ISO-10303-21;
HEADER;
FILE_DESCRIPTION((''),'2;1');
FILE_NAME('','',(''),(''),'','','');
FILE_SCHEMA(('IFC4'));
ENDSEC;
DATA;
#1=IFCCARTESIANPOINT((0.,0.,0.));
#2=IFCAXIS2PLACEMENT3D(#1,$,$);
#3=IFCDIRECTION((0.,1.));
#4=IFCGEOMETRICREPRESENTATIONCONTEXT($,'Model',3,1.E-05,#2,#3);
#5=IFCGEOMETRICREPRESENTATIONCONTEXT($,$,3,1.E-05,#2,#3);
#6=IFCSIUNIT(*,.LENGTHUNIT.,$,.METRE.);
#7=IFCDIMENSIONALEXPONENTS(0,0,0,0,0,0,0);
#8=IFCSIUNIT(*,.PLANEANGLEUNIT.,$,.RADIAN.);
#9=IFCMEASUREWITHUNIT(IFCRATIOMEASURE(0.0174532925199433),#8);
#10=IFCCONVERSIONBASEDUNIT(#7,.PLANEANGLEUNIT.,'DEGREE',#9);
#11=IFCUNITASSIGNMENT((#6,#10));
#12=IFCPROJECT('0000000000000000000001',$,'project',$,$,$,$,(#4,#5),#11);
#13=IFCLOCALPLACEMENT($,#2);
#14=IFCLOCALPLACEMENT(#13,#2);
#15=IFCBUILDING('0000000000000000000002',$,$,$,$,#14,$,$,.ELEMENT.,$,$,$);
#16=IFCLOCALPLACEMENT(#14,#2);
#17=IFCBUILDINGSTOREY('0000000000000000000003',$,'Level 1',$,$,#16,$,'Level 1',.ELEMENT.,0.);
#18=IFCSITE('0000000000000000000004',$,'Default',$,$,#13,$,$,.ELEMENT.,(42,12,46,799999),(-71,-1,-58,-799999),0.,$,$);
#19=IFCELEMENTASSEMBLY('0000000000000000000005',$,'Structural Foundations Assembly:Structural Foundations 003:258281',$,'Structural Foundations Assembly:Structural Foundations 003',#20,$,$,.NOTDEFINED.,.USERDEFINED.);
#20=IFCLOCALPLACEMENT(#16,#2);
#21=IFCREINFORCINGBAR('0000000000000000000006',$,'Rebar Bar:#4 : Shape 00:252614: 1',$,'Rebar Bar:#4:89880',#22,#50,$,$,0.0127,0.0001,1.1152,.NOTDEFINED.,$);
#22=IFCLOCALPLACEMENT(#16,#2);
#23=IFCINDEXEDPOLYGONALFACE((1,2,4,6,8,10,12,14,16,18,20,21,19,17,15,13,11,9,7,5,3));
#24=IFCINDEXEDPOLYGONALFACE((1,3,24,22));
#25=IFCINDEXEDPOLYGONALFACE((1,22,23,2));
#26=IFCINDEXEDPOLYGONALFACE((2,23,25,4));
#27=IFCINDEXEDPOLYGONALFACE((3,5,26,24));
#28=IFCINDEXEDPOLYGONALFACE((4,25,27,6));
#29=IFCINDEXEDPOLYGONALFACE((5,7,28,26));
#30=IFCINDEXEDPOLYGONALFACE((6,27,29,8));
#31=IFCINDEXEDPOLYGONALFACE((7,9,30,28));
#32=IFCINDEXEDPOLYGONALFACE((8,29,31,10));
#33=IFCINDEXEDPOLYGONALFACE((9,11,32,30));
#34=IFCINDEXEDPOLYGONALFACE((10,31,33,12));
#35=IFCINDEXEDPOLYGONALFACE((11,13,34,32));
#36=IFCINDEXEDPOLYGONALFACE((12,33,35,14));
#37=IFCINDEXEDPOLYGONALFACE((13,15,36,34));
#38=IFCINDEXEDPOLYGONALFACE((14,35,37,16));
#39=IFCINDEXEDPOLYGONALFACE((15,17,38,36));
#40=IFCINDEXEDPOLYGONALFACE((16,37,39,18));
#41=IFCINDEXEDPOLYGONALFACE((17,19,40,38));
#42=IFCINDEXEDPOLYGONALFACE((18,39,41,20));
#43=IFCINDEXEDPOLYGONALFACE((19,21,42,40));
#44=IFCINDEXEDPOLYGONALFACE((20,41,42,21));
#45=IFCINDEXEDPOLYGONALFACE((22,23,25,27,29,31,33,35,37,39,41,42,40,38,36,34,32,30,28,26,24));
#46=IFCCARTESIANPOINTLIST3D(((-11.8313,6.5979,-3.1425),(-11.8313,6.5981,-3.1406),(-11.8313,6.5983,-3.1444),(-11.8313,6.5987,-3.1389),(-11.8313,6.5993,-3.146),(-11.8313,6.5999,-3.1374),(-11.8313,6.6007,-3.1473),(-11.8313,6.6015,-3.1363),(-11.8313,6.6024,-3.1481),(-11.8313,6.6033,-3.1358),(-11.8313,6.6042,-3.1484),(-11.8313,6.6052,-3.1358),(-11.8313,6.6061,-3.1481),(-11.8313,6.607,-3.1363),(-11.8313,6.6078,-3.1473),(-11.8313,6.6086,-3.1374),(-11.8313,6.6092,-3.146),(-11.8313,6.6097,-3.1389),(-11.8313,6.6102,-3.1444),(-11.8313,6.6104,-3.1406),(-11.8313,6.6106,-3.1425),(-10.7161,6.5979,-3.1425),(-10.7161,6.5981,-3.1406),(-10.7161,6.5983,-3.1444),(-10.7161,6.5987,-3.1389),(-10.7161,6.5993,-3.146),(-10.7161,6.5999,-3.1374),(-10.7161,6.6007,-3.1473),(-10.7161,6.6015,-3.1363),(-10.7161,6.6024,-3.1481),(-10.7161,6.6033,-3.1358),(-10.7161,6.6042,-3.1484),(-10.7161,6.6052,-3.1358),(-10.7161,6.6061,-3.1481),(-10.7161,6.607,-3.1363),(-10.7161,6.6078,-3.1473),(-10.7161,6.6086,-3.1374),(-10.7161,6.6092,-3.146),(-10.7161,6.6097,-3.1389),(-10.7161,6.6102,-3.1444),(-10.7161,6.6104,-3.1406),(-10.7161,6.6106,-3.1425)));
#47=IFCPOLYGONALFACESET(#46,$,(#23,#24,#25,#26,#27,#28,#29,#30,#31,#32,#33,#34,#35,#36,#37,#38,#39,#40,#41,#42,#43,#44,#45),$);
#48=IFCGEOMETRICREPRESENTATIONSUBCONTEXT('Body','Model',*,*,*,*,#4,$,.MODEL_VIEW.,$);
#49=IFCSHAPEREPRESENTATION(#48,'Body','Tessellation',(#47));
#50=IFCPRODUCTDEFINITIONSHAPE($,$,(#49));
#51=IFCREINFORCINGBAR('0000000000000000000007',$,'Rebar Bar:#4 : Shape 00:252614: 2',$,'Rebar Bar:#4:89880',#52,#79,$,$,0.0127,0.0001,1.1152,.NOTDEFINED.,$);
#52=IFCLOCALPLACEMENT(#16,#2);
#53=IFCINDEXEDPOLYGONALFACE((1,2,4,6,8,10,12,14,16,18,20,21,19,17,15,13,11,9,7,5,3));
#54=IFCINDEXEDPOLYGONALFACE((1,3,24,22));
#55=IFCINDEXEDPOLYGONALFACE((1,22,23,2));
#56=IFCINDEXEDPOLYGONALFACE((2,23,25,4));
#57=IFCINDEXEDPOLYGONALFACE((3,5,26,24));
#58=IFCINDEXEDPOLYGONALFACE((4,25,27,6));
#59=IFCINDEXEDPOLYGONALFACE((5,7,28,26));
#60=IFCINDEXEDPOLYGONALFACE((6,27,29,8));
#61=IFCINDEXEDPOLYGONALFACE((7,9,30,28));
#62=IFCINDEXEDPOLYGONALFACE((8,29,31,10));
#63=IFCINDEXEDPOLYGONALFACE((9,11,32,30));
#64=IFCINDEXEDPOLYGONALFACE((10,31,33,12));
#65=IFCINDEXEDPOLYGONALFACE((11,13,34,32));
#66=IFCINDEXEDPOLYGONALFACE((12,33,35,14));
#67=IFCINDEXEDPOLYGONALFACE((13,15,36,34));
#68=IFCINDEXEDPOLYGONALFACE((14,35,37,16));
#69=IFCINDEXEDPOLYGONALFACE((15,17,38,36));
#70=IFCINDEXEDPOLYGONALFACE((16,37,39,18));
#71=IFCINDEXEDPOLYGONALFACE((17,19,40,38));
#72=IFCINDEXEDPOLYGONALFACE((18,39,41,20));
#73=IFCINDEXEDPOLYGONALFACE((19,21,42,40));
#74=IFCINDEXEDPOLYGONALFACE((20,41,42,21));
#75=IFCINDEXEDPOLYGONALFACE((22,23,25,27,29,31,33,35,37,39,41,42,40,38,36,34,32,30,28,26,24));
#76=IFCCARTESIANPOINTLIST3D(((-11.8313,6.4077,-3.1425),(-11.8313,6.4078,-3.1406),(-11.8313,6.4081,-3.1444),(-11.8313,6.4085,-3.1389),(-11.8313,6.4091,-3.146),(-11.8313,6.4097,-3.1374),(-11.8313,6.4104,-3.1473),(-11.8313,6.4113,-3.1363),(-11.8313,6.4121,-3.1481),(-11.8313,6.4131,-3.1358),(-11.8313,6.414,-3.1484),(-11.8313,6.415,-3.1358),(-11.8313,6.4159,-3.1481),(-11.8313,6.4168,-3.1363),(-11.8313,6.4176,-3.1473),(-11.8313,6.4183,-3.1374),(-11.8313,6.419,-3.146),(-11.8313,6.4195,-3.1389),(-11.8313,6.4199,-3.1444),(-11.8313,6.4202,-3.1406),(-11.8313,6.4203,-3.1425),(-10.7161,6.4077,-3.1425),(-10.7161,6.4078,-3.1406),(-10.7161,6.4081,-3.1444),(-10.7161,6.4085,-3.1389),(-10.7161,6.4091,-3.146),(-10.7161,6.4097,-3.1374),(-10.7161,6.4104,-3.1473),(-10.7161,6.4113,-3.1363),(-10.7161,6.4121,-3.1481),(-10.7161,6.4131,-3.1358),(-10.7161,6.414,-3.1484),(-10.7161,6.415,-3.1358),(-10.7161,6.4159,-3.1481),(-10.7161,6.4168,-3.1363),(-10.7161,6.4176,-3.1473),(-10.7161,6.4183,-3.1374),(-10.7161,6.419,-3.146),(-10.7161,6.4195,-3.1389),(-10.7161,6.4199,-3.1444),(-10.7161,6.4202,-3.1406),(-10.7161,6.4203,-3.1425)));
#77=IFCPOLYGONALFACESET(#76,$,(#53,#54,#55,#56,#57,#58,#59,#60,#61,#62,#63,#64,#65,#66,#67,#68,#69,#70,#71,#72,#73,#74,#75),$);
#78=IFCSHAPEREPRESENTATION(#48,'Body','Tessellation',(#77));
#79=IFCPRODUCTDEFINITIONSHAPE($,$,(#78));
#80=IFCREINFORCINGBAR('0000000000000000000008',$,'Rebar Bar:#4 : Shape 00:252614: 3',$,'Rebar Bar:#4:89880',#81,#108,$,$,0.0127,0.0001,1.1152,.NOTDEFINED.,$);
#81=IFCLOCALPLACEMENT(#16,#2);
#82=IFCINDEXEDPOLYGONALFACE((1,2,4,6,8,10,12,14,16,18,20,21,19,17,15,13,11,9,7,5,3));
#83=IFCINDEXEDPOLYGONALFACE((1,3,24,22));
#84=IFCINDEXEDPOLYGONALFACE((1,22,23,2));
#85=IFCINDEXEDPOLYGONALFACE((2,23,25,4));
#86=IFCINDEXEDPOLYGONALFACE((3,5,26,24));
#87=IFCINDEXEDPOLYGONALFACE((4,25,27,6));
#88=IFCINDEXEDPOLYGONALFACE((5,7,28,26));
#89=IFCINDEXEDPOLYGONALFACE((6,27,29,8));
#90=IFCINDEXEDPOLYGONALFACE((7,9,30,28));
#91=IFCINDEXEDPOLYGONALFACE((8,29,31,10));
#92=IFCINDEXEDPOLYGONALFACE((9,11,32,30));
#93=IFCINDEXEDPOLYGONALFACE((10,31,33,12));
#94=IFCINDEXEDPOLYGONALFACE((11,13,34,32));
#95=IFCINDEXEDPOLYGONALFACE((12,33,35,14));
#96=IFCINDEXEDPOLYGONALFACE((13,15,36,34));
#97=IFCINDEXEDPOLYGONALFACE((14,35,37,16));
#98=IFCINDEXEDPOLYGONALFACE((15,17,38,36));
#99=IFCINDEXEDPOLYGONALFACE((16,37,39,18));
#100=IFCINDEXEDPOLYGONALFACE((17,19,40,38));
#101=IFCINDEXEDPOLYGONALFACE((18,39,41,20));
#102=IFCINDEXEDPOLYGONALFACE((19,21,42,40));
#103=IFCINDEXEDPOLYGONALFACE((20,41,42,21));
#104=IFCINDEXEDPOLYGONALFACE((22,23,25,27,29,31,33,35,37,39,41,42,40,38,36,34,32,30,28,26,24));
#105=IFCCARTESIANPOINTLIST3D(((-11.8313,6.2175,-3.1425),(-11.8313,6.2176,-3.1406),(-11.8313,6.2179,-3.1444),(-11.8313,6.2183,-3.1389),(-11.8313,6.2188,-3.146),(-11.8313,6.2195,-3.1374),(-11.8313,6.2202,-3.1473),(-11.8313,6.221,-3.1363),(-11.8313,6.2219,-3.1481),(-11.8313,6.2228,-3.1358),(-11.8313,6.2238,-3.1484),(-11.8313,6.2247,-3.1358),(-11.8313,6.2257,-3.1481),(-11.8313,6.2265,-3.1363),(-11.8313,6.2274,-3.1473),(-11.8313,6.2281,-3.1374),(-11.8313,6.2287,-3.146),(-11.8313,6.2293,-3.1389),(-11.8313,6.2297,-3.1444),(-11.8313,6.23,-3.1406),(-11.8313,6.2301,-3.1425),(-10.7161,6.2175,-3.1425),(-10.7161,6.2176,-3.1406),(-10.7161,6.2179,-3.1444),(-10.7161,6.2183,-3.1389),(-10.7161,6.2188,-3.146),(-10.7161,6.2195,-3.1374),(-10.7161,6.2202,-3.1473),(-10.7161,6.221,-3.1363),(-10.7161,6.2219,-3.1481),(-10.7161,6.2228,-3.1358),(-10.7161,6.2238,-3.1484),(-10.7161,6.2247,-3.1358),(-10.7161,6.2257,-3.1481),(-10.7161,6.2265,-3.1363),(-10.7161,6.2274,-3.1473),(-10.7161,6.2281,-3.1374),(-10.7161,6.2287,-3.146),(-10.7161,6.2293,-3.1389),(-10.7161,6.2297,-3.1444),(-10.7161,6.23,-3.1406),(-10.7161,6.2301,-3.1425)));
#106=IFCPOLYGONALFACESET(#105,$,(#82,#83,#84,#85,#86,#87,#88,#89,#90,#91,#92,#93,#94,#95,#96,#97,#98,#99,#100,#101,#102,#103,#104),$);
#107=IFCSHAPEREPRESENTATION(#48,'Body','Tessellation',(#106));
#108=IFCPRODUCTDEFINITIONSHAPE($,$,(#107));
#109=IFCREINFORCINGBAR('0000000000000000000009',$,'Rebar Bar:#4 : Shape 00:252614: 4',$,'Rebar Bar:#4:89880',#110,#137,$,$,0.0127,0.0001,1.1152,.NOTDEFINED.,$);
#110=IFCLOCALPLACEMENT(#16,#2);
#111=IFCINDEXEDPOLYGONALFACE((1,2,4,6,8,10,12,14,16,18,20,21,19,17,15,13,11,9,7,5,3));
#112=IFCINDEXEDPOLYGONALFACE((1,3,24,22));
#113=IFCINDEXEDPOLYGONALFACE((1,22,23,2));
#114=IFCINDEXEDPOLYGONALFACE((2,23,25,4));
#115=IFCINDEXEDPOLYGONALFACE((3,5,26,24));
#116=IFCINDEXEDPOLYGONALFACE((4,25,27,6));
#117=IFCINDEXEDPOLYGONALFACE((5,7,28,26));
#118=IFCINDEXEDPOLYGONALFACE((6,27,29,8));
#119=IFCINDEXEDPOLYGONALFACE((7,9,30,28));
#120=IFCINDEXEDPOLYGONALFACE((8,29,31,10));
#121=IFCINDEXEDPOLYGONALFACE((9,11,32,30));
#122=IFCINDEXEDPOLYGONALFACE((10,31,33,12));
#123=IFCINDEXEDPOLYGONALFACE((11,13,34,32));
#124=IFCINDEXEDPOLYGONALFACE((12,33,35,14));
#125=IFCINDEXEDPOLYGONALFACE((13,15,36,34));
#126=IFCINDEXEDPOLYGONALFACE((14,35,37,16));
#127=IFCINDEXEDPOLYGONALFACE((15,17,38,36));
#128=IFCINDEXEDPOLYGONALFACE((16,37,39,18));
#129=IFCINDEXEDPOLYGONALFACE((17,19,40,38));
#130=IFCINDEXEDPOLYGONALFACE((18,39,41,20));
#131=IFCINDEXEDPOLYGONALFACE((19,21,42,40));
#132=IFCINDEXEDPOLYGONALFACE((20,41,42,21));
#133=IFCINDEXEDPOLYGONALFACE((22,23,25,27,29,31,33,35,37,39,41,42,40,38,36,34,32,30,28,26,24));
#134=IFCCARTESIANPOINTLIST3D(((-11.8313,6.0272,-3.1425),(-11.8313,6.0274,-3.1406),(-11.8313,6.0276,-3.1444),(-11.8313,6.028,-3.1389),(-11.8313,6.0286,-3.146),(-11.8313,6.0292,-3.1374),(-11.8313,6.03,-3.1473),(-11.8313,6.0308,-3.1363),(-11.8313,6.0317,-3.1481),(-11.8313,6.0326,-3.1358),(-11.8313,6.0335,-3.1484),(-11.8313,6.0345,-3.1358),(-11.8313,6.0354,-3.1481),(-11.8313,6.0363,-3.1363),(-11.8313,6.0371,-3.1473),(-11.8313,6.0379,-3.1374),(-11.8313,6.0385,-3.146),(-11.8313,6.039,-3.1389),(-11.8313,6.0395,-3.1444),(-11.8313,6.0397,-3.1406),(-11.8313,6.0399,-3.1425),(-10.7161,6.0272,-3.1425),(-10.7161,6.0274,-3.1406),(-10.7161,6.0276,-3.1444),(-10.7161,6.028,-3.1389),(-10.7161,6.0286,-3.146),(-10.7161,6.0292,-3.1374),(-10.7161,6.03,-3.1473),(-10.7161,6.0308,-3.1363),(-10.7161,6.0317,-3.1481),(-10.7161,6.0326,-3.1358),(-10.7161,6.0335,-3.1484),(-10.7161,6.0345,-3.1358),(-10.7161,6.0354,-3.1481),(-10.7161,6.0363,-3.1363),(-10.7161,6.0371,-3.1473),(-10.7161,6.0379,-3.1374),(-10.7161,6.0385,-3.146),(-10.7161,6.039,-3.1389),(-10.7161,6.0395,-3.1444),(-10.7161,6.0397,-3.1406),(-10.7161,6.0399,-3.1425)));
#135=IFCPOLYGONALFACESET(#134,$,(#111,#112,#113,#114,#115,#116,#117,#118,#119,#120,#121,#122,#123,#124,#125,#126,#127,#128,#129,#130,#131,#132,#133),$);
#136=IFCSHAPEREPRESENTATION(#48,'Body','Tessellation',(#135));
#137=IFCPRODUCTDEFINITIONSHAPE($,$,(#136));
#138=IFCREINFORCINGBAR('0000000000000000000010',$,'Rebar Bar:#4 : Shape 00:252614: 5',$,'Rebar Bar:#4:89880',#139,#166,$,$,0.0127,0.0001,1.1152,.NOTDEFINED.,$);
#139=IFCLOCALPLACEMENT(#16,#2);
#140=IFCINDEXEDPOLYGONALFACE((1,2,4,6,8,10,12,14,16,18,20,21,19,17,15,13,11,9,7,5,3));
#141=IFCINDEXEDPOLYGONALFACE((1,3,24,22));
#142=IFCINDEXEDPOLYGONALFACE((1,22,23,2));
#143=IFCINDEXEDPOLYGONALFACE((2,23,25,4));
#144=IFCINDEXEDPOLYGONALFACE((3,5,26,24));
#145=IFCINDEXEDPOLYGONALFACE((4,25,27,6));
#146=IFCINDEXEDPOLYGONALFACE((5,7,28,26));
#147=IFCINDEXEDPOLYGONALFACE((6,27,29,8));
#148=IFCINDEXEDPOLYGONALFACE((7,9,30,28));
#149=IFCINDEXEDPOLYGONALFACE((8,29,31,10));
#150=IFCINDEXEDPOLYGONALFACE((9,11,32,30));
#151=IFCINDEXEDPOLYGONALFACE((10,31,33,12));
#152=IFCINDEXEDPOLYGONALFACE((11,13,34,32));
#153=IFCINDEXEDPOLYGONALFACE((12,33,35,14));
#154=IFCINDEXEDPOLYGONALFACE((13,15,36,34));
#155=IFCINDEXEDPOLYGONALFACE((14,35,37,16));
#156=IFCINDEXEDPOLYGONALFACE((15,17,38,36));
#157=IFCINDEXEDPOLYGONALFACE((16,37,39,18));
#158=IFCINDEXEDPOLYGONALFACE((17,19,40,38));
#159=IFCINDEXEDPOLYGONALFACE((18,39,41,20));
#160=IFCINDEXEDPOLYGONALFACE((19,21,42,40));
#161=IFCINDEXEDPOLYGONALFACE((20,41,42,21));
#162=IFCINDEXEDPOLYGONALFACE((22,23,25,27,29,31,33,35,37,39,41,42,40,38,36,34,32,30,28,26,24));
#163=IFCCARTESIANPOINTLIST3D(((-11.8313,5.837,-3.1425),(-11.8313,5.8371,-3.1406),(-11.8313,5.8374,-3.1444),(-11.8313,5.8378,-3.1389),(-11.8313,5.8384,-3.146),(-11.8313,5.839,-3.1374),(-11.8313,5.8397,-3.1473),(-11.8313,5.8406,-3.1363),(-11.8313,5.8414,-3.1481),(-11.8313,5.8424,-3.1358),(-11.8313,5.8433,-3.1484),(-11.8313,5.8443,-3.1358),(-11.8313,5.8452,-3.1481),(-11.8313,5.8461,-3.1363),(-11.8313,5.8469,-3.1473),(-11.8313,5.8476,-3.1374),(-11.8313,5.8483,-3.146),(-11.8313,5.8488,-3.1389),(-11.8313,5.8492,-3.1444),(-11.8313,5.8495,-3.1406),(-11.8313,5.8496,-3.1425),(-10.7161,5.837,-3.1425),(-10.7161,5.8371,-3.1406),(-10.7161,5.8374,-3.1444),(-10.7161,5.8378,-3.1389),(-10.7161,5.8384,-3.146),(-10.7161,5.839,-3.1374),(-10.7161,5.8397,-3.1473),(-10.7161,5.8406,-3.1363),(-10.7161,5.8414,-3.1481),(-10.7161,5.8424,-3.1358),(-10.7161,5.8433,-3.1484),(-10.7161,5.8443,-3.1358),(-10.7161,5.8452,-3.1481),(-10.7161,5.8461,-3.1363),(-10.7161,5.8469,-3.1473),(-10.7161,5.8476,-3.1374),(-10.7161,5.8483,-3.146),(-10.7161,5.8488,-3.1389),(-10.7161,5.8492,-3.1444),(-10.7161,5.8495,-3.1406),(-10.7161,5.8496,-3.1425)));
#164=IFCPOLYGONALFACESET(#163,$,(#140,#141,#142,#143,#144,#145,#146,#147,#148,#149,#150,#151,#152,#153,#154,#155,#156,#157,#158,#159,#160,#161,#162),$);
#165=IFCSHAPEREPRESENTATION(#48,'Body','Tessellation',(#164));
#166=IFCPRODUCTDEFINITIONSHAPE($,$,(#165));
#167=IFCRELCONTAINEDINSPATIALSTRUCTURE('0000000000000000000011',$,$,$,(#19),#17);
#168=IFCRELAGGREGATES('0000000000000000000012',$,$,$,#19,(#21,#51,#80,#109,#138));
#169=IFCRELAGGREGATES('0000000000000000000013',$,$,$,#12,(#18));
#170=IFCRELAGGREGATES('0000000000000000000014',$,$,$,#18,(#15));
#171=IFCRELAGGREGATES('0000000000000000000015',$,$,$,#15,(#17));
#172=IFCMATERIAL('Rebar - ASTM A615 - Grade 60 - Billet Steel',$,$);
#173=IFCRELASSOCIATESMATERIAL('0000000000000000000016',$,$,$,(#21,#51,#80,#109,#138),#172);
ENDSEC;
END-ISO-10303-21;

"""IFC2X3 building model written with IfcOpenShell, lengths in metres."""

from ifc_helpers import new_model, entity, si_unit, converted_unit, direction, origin, place, context, subcontext, project, spatial, material, element, aggregate, save


model = new_model("IFC2X3")

# Units and contexts
model_context = context("Model", 3, precision=1e-05, world=origin(), true_north=direction((0.0, 1.0)))
context_of_model = context(None, 3, precision=1e-05, world=origin(), true_north=direction((0.0, 1.0)))
body_context = subcontext(model_context, "Body", "Model", "MODEL_VIEW")
ifc_project = project(units=[si_unit("LENGTHUNIT", "METRE"), converted_unit("PLANEANGLEUNIT", "DEGREE", entity("IfcRatioMeasure", 0.0174532925199433), si_unit("PLANEANGLEUNIT", "RADIAN"), dimensions=[0, 0, 0, 0, 0, 0, 0])], contexts=[model_context, context_of_model])

# Site, building, storey
site_placement = place(None, origin())
site = spatial("IfcSite", under=ifc_project, at=site_placement, Name="Default", CompositionType="ELEMENT", RefLatitude=(42, 12, 46, 799999), RefLongitude=(-71, -1, -58, -799999), RefElevation=0.0)
building_placement = place(site_placement, origin())
building = spatial("IfcBuilding", under=site, at=building_placement, CompositionType="ELEMENT")
storey_placement = place(building_placement, origin())
storey = spatial("IfcBuildingStorey", under=building, at=storey_placement, Name="Level 1", LongName="Level 1", CompositionType="ELEMENT", Elevation=0.0)

# Element assembly
assembly_1_placement = place(storey_placement, origin())
assembly_1 = element("IfcElementAssembly", 1, at=assembly_1_placement, inside=storey, Name="Structural Foundations Assembly:Structural Foundations 003:258281", ObjectType="Structural Foundations Assembly:Structural Foundations 003", AssemblyPlace="NOTDEFINED", PredefinedType="USERDEFINED")

# Shared definitions
ifc_material_1 = material(Name="Rebar - ASTM A615 - Grade 60 - Billet Steel")

# Reinforcing bars
reinforcing_bar_1_placement = place(assembly_1_placement, origin())
reinforcing_bar_1 = element("IfcReinforcingBar", 2, at=reinforcing_bar_1_placement, material=ifc_material_1, Name="Rebar Bar:#4 : Shape 00:252614: 1", ObjectType="Rebar Bar:#4:89880", BarLength=1.1152, BarRole="NOTDEFINED", CrossSectionArea=0.0001, NominalDiameter=0.0127, context=body_context, shape_type="AdvancedSweptSolid", body=[
    entity("IfcSweptDiskSolid", entity("IfcCompositeCurve", [entity("IfcCompositeCurveSegment", "CONTINUOUS", True, entity("IfcPolyline", [entity("IfcCartesianPoint", [-10.7161, 6.6042, -3.142]), entity("IfcCartesianPoint", [-11.8313, 6.6042, -3.142])]))], False), 0.0063, None, 0.0, 1.0),
])
reinforcing_bar_2_placement = place(assembly_1_placement, origin())
reinforcing_bar_2 = element("IfcReinforcingBar", 3, at=reinforcing_bar_2_placement, material=ifc_material_1, Name="Rebar Bar:#4 : Shape 00:252614: 2", ObjectType="Rebar Bar:#4:89880", BarLength=1.1152, BarRole="NOTDEFINED", CrossSectionArea=0.0001, NominalDiameter=0.0127, context=body_context, shape_type="AdvancedSweptSolid", body=[
    entity("IfcSweptDiskSolid", entity("IfcCompositeCurve", [entity("IfcCompositeCurveSegment", "CONTINUOUS", True, entity("IfcPolyline", [entity("IfcCartesianPoint", [-10.7161, 6.414, -3.142]), entity("IfcCartesianPoint", [-11.8313, 6.414, -3.142])]))], False), 0.0063, None, 0.0, 1.0),
])
reinforcing_bar_3_placement = place(assembly_1_placement, origin())
reinforcing_bar_3 = element("IfcReinforcingBar", 4, at=reinforcing_bar_3_placement, material=ifc_material_1, Name="Rebar Bar:#4 : Shape 00:252614: 3", ObjectType="Rebar Bar:#4:89880", BarLength=1.1152, BarRole="NOTDEFINED", CrossSectionArea=0.0001, NominalDiameter=0.0127, context=body_context, shape_type="AdvancedSweptSolid", body=[
    entity("IfcSweptDiskSolid", entity("IfcCompositeCurve", [entity("IfcCompositeCurveSegment", "CONTINUOUS", True, entity("IfcPolyline", [entity("IfcCartesianPoint", [-10.7161, 6.2238, -3.142]), entity("IfcCartesianPoint", [-11.8313, 6.2238, -3.142])]))], False), 0.0063, None, 0.0, 1.0),
])
reinforcing_bar_4_placement = place(assembly_1_placement, origin())
reinforcing_bar_4 = element("IfcReinforcingBar", 5, at=reinforcing_bar_4_placement, material=ifc_material_1, Name="Rebar Bar:#4 : Shape 00:252614: 4", ObjectType="Rebar Bar:#4:89880", BarLength=1.1152, BarRole="NOTDEFINED", CrossSectionArea=0.0001, NominalDiameter=0.0127, context=body_context, shape_type="AdvancedSweptSolid", body=[
    entity("IfcSweptDiskSolid", entity("IfcCompositeCurve", [entity("IfcCompositeCurveSegment", "CONTINUOUS", True, entity("IfcPolyline", [entity("IfcCartesianPoint", [-10.7161, 6.0335, -3.142]), entity("IfcCartesianPoint", [-11.8313, 6.0335, -3.142])]))], False), 0.0063, None, 0.0, 1.0),
])
reinforcing_bar_5_placement = place(assembly_1_placement, origin())
reinforcing_bar_5 = element("IfcReinforcingBar", 6, at=reinforcing_bar_5_placement, material=ifc_material_1, Name="Rebar Bar:#4 : Shape 00:252614: 5", ObjectType="Rebar Bar:#4:89880", BarLength=1.1152, BarRole="NOTDEFINED", CrossSectionArea=0.0001, NominalDiameter=0.0127, context=body_context, shape_type="AdvancedSweptSolid", body=[
    entity("IfcSweptDiskSolid", entity("IfcCompositeCurve", [entity("IfcCompositeCurveSegment", "CONTINUOUS", True, entity("IfcPolyline", [entity("IfcCartesianPoint", [-10.7161, 5.8433, -3.142]), entity("IfcCartesianPoint", [-11.8313, 5.8433, -3.142])]))], False), 0.0063, None, 0.0, 1.0),
])
aggregate(assembly_1, [reinforcing_bar_1, reinforcing_bar_2, reinforcing_bar_3, reinforcing_bar_4, reinforcing_bar_5])

save(model, "model.ifc")
